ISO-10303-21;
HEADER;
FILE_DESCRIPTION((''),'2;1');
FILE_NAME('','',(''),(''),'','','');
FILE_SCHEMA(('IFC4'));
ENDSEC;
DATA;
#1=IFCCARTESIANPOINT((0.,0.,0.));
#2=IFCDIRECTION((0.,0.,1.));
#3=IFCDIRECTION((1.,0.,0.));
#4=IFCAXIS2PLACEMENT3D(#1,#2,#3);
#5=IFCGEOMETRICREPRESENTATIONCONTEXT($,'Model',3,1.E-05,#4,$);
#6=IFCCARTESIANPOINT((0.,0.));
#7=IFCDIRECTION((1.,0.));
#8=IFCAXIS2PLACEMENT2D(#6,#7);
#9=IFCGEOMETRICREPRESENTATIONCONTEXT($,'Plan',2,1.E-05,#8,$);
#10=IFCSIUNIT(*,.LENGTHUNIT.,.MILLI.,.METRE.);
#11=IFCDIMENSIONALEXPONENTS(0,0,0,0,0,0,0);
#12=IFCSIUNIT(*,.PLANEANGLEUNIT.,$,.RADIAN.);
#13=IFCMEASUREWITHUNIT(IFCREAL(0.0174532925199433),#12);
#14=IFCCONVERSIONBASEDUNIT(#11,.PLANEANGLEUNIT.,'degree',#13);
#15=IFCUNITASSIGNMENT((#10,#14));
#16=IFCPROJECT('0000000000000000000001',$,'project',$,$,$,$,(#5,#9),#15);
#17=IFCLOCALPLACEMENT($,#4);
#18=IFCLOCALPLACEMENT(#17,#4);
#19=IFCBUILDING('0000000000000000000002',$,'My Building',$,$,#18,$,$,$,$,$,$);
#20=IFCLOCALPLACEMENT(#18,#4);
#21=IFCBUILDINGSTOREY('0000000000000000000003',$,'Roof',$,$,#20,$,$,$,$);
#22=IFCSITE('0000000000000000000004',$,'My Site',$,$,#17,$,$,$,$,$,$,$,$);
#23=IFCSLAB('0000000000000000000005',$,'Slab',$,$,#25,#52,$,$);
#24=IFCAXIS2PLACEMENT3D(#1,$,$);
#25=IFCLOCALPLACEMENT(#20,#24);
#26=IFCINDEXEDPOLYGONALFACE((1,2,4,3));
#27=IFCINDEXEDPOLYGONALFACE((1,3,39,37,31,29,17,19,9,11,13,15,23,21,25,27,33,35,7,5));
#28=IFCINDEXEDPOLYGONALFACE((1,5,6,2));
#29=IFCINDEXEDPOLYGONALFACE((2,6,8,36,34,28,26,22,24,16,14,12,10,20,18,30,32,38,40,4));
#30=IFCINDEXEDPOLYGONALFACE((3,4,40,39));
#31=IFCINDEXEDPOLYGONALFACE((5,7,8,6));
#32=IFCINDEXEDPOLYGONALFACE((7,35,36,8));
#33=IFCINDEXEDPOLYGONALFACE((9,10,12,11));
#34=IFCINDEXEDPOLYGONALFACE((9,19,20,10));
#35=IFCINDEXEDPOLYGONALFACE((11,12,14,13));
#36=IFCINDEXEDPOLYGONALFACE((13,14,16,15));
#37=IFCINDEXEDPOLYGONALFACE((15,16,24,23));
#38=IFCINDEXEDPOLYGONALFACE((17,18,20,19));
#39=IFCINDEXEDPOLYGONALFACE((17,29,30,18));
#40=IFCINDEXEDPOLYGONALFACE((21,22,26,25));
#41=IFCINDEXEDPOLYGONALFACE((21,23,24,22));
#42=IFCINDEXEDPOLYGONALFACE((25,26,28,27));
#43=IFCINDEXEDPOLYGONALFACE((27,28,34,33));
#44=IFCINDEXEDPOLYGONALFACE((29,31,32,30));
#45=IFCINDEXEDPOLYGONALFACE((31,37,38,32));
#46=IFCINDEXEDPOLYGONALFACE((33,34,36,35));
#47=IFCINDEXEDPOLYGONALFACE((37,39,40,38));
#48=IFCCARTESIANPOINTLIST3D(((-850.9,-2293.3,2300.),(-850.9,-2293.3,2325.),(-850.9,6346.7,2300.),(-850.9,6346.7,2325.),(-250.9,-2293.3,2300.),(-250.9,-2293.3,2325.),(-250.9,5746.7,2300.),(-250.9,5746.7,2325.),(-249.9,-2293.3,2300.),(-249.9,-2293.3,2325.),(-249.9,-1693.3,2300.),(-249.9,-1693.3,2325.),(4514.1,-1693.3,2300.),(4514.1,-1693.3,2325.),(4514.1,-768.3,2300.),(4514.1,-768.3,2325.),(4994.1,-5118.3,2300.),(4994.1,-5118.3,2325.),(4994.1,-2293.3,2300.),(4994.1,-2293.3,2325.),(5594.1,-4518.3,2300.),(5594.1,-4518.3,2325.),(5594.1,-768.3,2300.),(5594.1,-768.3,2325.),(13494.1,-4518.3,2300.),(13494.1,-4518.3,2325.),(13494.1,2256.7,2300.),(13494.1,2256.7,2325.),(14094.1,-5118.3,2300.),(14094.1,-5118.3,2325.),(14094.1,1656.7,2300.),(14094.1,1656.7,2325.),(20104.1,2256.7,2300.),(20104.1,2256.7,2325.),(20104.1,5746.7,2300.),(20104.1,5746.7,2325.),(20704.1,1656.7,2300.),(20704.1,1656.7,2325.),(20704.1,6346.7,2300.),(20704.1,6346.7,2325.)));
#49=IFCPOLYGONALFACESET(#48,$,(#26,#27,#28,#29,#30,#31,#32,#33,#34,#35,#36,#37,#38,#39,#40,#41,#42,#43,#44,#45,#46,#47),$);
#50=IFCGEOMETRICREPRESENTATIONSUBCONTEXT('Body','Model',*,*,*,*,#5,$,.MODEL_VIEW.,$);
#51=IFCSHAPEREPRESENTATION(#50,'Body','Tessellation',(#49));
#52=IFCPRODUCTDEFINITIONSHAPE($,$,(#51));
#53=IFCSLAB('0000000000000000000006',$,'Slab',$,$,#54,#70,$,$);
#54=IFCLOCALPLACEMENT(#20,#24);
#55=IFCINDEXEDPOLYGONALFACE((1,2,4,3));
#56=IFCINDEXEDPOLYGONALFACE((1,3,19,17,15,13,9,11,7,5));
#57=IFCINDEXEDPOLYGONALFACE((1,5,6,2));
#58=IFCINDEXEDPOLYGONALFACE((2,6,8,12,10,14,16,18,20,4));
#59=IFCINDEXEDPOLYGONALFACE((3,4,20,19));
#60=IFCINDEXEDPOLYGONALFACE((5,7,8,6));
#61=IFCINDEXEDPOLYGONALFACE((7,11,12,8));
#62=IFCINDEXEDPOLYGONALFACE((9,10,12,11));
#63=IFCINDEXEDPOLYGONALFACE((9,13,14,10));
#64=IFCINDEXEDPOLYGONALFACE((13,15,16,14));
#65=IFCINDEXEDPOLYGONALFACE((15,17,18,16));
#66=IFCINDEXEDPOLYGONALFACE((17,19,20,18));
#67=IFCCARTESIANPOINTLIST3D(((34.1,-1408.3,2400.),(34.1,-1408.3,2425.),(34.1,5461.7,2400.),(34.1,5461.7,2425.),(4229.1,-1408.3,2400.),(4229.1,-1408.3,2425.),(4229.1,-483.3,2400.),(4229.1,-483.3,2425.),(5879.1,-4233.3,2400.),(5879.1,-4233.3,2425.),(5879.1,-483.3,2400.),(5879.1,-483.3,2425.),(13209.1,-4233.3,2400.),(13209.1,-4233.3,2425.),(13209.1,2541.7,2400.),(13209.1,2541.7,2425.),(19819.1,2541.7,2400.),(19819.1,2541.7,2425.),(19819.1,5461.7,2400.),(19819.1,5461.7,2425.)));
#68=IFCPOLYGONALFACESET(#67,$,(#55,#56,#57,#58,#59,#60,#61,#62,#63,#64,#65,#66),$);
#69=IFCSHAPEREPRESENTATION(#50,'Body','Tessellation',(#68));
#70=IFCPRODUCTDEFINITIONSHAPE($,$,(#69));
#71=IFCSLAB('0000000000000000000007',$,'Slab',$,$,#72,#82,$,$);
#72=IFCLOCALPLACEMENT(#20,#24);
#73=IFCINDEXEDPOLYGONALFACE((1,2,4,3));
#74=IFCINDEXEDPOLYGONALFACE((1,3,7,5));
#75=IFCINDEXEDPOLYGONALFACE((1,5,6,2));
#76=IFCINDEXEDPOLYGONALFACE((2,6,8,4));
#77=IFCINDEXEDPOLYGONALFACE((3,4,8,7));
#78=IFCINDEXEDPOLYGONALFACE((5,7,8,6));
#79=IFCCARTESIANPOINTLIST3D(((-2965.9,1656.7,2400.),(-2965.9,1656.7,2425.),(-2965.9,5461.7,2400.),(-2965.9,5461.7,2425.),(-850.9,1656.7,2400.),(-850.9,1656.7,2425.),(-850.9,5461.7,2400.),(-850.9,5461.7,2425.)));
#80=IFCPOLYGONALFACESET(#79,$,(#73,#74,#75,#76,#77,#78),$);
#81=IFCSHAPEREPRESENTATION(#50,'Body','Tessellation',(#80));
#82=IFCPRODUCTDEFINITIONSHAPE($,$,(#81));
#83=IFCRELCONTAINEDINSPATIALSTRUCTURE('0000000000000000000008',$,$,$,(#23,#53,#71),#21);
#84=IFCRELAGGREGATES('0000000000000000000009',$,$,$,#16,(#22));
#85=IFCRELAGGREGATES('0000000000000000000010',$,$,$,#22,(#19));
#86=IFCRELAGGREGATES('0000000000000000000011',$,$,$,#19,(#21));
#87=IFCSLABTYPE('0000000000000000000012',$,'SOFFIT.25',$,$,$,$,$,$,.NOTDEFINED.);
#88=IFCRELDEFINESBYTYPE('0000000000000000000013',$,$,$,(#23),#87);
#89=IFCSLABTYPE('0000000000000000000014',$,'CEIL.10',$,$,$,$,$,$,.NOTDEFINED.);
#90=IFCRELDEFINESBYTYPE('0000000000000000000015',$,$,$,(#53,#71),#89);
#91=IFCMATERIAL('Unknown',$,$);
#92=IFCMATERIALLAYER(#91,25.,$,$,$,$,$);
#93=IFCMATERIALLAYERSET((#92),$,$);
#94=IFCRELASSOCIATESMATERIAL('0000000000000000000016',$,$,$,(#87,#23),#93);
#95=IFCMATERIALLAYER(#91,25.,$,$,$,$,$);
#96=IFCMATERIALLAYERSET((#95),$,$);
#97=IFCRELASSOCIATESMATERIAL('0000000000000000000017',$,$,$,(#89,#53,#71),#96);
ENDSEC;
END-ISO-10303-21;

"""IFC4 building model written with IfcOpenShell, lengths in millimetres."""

from ifc_helpers import new_model, entity, si_unit, converted_unit, frame, origin_with_axes, origin_2d_with_axis, place, context, subcontext, project, spatial, line, indexed_curve, outline, extrude, material, layer, layer_set, layer_usage, type_object, element, save


model = new_model("IFC4")

# Units and contexts
model_context = context("Model", 3, precision=1e-05, world=origin_with_axes())
plan_context = context("Plan", 2, precision=1e-05, world=origin_2d_with_axis())
body_context = subcontext(model_context, "Body", "Model", "MODEL_VIEW")
ifc_project = project(units=[si_unit("LENGTHUNIT", "METRE", prefix="MILLI"), converted_unit("PLANEANGLEUNIT", "degree", entity("IfcReal", 0.0174532925199433), si_unit("PLANEANGLEUNIT", "RADIAN"), dimensions=[0, 0, 0, 0, 0, 0, 0])], contexts=[model_context, plan_context])

# Site, building, storey
site_placement = place(None, origin_with_axes())
site = spatial("IfcSite", under=ifc_project, at=site_placement, Name="My Site")
building_placement = place(site_placement, origin_with_axes())
building = spatial("IfcBuilding", under=site, at=building_placement, Name="My Building")
storey_placement = place(building_placement, origin_with_axes())
storey = spatial("IfcBuildingStorey", under=building, at=storey_placement, Name="Roof")

# Slabs
ifc_material = material(Name="Unknown")
ifc_layer_1 = layer(ifc_material, 25.0)
ifc_layer_set_1 = layer_set([ifc_layer_1])
ifc_layer_usage_1 = layer_usage(ifc_layer_set_1, "AXIS3", "POSITIVE", 0.0)
slab_type_1 = type_object("IfcSlabType", Name="SOFFIT.25", PredefinedType="NOTDEFINED", material=ifc_layer_set_1)
slab_1_placement = place(storey_placement, frame((-850.9, -2293.3, 2300.0), z_axis=(0.0, 0.0, 1.0), x_axis=(1.0, 0.0, 0.0)))
element("IfcSlab", 1, at=slab_1_placement, inside=storey, type_object=slab_type_1, material=ifc_layer_usage_1, Name="Slab", context=body_context, shape_type="SweptSolid", body=[
    extrude(outline(indexed_curve([(0.0, 0.0), (600.0, 0.0), (21555.0, 8640.0), (0.0, 8640.0), (600.0, 8040.0), (20955.0, 8040.0), (21555.0, 3950.0), (14945.0, 3950.0), (20955.0, 4550.0), (14345.0, 4550.0), (5845.0, -2825.0), (14945.0, -2825.0), (14345.0, -2225.0), (5845.0, 0.0), (6445.0, -2225.0), (6445.0, 1525.0), (5365.0, 1525.0), (5365.0, 600.0), (601.0, 600.0), (601.0, 0.0)], segments=[line(15, 13), line(13, 10), line(10, 9), line(9, 6), line(6, 5), line(5, 2), line(2, 1), line(1, 4), line(4, 3), line(3, 7), line(7, 8), line(8, 12), line(12, 11), line(11, 14), line(14, 20), line(20, 19), line(19, 18), line(18, 17), line(17, 16), line(16, 15)], self_intersect=False)), None, (0.0, 0.0, 1.0), 25.0),
])
ifc_layer_2 = layer(ifc_material, 25.0)
ifc_layer_set_2 = layer_set([ifc_layer_2])
ifc_layer_usage_2 = layer_usage(ifc_layer_set_2, "AXIS3", "POSITIVE", 0.0)
slab_type_2 = type_object("IfcSlabType", Name="CEIL.10", PredefinedType="NOTDEFINED", material=ifc_layer_set_2)
slab_2_placement = place(storey_placement, frame((34.1, -1408.3, 2400.0), z_axis=(0.0, 0.0, 1.0), x_axis=(1.0, 0.0, 0.0)))
element("IfcSlab", 2, at=slab_2_placement, inside=storey, type_object=slab_type_2, material=ifc_layer_usage_2, Name="Slab", context=body_context, shape_type="SweptSolid", body=[
    extrude(outline(indexed_curve([(0.0, 0.0), (4195.0, 0.0), (19785.0, 6870.0), (0.0, 6870.0), (4195.0, 925.0), (19785.0, 3950.0), (13175.0, 3950.0), (5845.0, 925.0), (5845.0, -2825.0), (13175.0, -2825.0)], segments=[line(2, 5), line(5, 8), line(8, 9), line(9, 10), line(10, 7), line(7, 6), line(6, 3), line(3, 4), line(4, 1), line(1, 2)], self_intersect=False)), None, (0.0, 0.0, 1.0), 25.0),
])
ifc_layer_usage_3 = layer_usage(ifc_layer_set_2, "AXIS3", "POSITIVE", 0.0)
slab_3_placement = place(storey_placement, frame((-2965.9, 1656.7, 2400.0), z_axis=(0.0, 0.0, 1.0), x_axis=(1.0, 0.0, 0.0)))
element("IfcSlab", 3, at=slab_3_placement, inside=storey, type_object=slab_type_2, material=ifc_layer_usage_3, Name="Slab", context=body_context, shape_type="SweptSolid", body=[
    extrude(outline(indexed_curve([(0.0, 0.0), (2115.0, 0.0), (2115.0, 3805.0), (0.0, 3805.0)], segments=[line(3, 2), line(2, 1), line(1, 4), line(4, 3)], self_intersect=False)), None, (0.0, 0.0, 1.0), 25.0),
])

save(model, "model.ifc")
